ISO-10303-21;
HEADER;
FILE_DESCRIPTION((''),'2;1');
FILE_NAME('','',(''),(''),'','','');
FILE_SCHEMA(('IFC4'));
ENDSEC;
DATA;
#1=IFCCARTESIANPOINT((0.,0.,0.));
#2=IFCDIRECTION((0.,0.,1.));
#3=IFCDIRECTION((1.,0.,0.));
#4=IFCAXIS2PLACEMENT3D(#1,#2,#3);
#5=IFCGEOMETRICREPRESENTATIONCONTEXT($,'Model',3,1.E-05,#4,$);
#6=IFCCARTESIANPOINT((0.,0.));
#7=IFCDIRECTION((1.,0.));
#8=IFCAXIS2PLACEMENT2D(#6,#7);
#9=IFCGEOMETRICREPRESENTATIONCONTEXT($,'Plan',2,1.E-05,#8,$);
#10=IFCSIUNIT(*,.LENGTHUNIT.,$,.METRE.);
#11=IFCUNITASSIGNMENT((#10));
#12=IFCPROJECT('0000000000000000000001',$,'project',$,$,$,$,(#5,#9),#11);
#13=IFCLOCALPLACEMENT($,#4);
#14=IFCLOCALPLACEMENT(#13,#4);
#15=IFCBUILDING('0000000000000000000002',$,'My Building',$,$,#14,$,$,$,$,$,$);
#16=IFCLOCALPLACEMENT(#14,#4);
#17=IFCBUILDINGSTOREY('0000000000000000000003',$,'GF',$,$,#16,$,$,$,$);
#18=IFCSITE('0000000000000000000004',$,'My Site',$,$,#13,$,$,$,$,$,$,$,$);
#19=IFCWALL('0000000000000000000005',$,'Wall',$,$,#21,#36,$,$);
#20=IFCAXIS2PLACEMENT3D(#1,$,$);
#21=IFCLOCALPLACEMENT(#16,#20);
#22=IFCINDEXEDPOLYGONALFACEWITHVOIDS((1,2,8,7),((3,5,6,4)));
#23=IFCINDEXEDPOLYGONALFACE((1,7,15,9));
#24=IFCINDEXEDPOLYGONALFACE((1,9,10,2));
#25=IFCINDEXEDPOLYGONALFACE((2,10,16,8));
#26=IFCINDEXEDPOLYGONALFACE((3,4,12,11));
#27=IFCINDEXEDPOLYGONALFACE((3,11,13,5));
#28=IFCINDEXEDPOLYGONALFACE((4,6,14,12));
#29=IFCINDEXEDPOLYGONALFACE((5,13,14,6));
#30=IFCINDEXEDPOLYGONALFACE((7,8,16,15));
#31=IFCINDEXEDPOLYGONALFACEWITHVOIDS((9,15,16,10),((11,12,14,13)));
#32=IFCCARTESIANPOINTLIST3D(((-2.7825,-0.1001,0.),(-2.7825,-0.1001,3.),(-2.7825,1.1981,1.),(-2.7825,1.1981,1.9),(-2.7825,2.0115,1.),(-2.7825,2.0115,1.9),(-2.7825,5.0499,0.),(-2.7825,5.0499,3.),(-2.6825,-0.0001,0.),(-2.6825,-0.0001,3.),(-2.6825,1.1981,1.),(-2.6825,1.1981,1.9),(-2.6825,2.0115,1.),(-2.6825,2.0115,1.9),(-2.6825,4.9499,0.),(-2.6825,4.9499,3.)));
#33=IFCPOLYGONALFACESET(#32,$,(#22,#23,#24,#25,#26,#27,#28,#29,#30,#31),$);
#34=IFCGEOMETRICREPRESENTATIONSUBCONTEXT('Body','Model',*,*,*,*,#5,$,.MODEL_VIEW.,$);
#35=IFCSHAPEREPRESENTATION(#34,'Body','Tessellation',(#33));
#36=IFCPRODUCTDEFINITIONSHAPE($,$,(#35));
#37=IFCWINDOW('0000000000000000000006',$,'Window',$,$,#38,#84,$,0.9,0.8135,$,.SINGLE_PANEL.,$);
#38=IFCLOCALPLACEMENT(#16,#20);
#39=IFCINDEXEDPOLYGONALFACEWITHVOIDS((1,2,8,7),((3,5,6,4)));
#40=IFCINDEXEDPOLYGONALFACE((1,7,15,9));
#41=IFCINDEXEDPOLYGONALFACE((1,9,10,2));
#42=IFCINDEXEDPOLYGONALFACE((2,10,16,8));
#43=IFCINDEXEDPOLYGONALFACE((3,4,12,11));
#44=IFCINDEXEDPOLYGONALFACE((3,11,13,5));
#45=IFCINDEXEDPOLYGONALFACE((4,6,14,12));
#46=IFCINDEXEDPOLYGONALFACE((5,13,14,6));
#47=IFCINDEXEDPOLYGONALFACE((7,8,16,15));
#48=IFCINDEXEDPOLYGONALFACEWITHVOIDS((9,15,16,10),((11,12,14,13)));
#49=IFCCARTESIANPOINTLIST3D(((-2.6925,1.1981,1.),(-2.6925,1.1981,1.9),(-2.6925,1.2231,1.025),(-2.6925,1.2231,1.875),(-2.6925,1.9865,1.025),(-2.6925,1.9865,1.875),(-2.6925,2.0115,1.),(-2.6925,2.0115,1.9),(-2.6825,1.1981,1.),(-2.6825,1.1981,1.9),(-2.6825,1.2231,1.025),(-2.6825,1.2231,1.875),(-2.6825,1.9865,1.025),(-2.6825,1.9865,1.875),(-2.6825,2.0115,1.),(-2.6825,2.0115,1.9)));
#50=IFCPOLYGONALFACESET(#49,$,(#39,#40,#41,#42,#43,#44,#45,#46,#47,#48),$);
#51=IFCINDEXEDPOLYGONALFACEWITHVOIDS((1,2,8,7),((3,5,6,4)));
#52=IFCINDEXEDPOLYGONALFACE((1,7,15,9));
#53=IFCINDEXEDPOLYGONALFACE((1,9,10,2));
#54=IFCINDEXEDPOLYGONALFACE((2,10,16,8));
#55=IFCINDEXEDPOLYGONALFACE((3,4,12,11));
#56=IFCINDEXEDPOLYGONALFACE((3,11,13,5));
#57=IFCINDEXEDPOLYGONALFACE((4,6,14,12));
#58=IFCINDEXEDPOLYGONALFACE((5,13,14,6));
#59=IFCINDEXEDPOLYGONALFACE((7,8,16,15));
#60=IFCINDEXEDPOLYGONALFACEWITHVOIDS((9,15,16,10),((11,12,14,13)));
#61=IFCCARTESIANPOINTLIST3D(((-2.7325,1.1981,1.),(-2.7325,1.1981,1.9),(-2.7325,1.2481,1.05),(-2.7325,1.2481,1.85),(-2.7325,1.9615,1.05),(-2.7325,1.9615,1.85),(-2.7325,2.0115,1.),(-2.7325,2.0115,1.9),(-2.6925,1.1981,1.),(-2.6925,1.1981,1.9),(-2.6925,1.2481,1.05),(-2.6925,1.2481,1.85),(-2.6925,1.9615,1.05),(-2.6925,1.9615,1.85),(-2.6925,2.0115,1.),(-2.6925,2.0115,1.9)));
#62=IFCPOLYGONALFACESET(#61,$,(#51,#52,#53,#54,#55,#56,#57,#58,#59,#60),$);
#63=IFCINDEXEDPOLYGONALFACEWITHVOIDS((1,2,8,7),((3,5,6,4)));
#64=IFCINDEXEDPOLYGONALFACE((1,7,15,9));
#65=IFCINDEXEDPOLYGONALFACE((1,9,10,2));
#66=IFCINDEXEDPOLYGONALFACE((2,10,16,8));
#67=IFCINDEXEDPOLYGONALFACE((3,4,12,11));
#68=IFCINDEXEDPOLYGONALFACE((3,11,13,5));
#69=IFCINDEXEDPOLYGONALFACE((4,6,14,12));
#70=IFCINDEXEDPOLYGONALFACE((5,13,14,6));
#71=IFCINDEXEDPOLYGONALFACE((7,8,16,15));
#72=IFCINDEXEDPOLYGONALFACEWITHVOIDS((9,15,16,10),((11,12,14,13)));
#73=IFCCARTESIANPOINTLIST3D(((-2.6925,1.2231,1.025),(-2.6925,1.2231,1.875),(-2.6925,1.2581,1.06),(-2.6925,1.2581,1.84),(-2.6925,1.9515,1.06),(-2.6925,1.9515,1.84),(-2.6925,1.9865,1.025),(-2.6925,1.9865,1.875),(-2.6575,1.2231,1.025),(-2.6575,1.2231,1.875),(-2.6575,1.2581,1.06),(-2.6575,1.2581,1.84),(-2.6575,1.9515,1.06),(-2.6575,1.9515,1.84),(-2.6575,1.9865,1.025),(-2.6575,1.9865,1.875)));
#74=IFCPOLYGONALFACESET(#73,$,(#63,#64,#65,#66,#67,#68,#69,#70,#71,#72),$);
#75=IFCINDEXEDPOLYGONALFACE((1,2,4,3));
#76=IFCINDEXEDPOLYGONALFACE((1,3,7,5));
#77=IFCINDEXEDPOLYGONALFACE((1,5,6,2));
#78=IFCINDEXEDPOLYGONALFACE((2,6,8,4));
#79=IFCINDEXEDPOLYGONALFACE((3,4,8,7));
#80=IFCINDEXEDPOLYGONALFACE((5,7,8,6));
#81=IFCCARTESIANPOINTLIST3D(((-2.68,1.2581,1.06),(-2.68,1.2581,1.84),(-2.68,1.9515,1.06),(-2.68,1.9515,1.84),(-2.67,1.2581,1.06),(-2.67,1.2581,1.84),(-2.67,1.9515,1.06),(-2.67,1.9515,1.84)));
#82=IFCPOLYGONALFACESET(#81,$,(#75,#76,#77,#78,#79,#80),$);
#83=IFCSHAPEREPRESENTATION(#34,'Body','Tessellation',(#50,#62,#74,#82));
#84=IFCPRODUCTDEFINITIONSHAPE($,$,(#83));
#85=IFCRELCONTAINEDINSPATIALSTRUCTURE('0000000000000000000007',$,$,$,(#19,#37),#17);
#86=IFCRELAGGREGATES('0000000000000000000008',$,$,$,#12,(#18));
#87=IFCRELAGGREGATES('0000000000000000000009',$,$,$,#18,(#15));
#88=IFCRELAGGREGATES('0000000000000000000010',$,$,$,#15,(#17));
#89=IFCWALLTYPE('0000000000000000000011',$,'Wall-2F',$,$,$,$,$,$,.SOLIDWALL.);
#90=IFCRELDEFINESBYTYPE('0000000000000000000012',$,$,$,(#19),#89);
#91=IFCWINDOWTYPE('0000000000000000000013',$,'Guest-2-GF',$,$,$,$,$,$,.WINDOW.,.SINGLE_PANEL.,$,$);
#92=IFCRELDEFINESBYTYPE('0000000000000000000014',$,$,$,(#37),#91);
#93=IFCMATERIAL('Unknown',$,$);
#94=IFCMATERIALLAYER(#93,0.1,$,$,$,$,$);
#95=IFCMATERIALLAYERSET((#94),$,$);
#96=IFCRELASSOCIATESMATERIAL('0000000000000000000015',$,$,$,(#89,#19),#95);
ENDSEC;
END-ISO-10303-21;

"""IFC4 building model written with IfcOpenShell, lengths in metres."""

from ifc_helpers import new_model, entity, si_unit, frame, origin_with_axes, origin_2d_with_axis, place, context, subcontext, project, spatial, line, indexed_curve, outline, extrude, shape, source, transform, mapped, material, layer, layer_set, layer_usage, type_object, type_shapes, element, fill, save


model = new_model("IFC4")

# Units and contexts
model_context = context("Model", 3, precision=1e-05, world=origin_with_axes())
plan_context = context("Plan", 2, precision=1e-05, world=origin_2d_with_axis())
body_context_1 = subcontext(model_context, "Body", "Model", "MODEL_VIEW")
body_context_2 = subcontext(plan_context, "Body", "Plan", "PLAN_VIEW")
ifc_project = project(units=[si_unit("LENGTHUNIT", "METRE")], contexts=[model_context, plan_context])

# Site, building, storey
site_placement = place(None, origin_with_axes())
site = spatial("IfcSite", under=ifc_project, at=site_placement, Name="My Site")
building_placement = place(site_placement, origin_with_axes())
building = spatial("IfcBuilding", under=site, at=building_placement, Name="My Building")
storey_placement = place(building_placement, origin_with_axes())
storey = spatial("IfcBuildingStorey", under=building, at=storey_placement, Name="GF")

# Shared definitions
ifc_material_1 = material(Name="Unknown")

# Shared definitions
ifc_layer_1 = layer(ifc_material_1, 0.1)
ifc_layer_set_1 = layer_set([ifc_layer_1])
wall_type = type_object("IfcWallType", Name="Wall-2F", PredefinedType="SOLIDWALL", material=ifc_layer_set_1)

# Wall, opening, window
ifc_layer_usage_1 = layer_usage(ifc_layer_set_1, "AXIS2", "POSITIVE", 0.0)
wall_1_placement = place(storey_placement, frame((-2.7825, 5.0499, 0.0), z_axis=(0.0, 0.0, 1.0), x_axis=(0.0, -1.0, 0.0)))
wall_1 = element("IfcWall", 1, at=wall_1_placement, inside=storey, type_object=wall_type, material=ifc_layer_usage_1, Name="Wall", context=body_context_1, shape_type="SweptSolid", body=[
    extrude(outline(indexed_curve([(0.0, 0.0), (0.1, 0.1), (5.05, 0.1), (5.15, 0.0)], segments=[line(1, 2, 3, 4, 1)])), origin_with_axes(), (0.0, 0.0, 1.0), 3.0),
])
shared_shape_1 = source(origin_with_axes(), body_context_1, "Body", "SweptSolid", [
    extrude(outline(indexed_curve([(0.0, 0.0), (0.8135, 0.0), (0.8135, 0.9), (0.0, 0.9)], segments=[line(1, 2, 3, 4, 1)])), frame((0.0, -0.6, 0.0), z_axis=(0.0, -1.0, 0.0), x_axis=(1.0, 0.0, 0.0)), (0.0, 0.0, -1.0), 1.2),
])
opening_1_placement = place(wall_1_placement, frame((3.0384, 0.0, 1.0), z_axis=(0.0, 0.0, 1.0), x_axis=(1.0, 0.0, 0.0)))
opening_1 = element("IfcOpeningElement", 2, at=opening_1_placement, cuts=wall_1, PredefinedType="OPENING", context=body_context_1, shape_type="MappedRepresentation", body=[
    mapped(shared_shape_1, transform((0.0, 0.0, 0.0), x_axis=(1.0, 0.0, 0.0), y_axis=(0.0, 1.0, 0.0), z_axis=(0.0, 0.0, 1.0), scale=1.0)),
])
window_type_1 = type_object("IfcWindowType", Name="Guest-2-GF", PartitioningType="SINGLE_PANEL", PredefinedType="WINDOW")
shared_shape_2 = source(origin_with_axes(), body_context_1, "Body", "SweptSolid", [
    extrude(outline(indexed_curve([(0.0, 0.0), (0.8135, 0.0), (0.8135, 0.9), (0.0, 0.9)], segments=[line(1, 2, 3, 4, 1)]), holes=[indexed_curve([(0.025, 0.025), (0.7885, 0.025), (0.7885, 0.875), (0.025, 0.875)], segments=[line(1, 2, 3, 4, 1)])]), frame((0.0, 0.09, 0.0), z_axis=(0.0, -1.0, 0.0), x_axis=(1.0, 0.0, 0.0)), (0.0, 0.0, -1.0), 0.01),
    extrude(outline(indexed_curve([(0.0, 0.0), (0.8135, 0.0), (0.8135, 0.9), (0.0, 0.9)], segments=[line(1, 2, 3, 4, 1)]), holes=[indexed_curve([(0.05, 0.05), (0.7635, 0.05), (0.7635, 0.85), (0.05, 0.85)], segments=[line(1, 2, 3, 4, 1)])]), frame((0.0, 0.05, 0.0), z_axis=(0.0, -1.0, 0.0), x_axis=(1.0, 0.0, 0.0)), (0.0, 0.0, -1.0), 0.04),
    extrude(outline(indexed_curve([(0.0, 0.0), (0.7635, 0.0), (0.7635, 0.85), (0.0, 0.85)], segments=[line(1, 2, 3, 4, 1)]), holes=[indexed_curve([(0.035, 0.035), (0.7285, 0.035), (0.7285, 0.815), (0.035, 0.815)], segments=[line(1, 2, 3, 4, 1)])]), frame((0.025, 0.09, 0.025), z_axis=(0.0, -1.0, 0.0), x_axis=(1.0, 0.0, 0.0)), (0.0, 0.0, -1.0), 0.035),
    extrude(outline(indexed_curve([(0.035, 0.035), (0.7285, 0.035), (0.7285, 0.815), (0.035, 0.815)], segments=[line(1, 2, 3, 4, 1)])), frame((0.025, 0.1025, 0.025), z_axis=(0.0, -1.0, 0.0), x_axis=(1.0, 0.0, 0.0)), (0.0, 0.0, -1.0), 0.01),
])
shared_shape_3 = source(origin_with_axes(), body_context_2, "Body", "Curve2D", [
    entity("IfcIndexedPolyCurve", entity("IfcCartesianPointList2D", [[0.05, 0.05], [0.7635, 0.05]])),
    entity("IfcIndexedPolyCurve", entity("IfcCartesianPointList2D", [[0.0, 0.1], [0.025, 0.1], [0.025, 0.09], [0.05, 0.09], [0.05, 0.05], [0.0, 0.05]]), [entity("IfcLineIndex", [1, 2, 3, 4, 5, 6, 1])]),
    entity("IfcIndexedPolyCurve", entity("IfcCartesianPointList2D", [[0.8135, 0.1], [0.7885, 0.1], [0.7885, 0.09], [0.7635, 0.09], [0.7635, 0.05], [0.8135, 0.05]]), [entity("IfcLineIndex", [1, 2, 3, 4, 5, 6, 1])]),
    entity("IfcIndexedPolyCurve", entity("IfcCartesianPointList2D", [[0.025, 0.09], [0.06, 0.09], [0.06, 0.125], [0.025, 0.125]]), [entity("IfcLineIndex", [1, 2, 3, 4, 1])]),
    entity("IfcIndexedPolyCurve", entity("IfcCartesianPointList2D", [[0.7885, 0.09], [0.7535, 0.09], [0.7535, 0.125], [0.7885, 0.125]]), [entity("IfcLineIndex", [1, 2, 3, 4, 1])]),
    entity("IfcIndexedPolyCurve", entity("IfcCartesianPointList2D", [[0.06, 0.09], [0.7535, 0.09]])),
    entity("IfcIndexedPolyCurve", entity("IfcCartesianPointList2D", [[0.06, 0.125], [0.7535, 0.125]])),
    entity("IfcIndexedPolyCurve", entity("IfcCartesianPointList2D", [[0.06, 0.1075], [0.7535, 0.1075]])),
])
type_shapes(window_type_1, [shared_shape_2, shared_shape_3])
window_1_placement = place(opening_1_placement, frame((0.0, 0.0, 0.0), z_axis=(0.0, 0.0, 1.0), x_axis=(1.0, 0.0, 0.0)))
window_1 = element("IfcWindow", 3, at=window_1_placement, inside=storey, type_object=window_type_1, Name="Window", OverallHeight=0.9, OverallWidth=0.8135, PartitioningType="SINGLE_PANEL", shapes=[
    shape(body_context_1, "Body", "MappedRepresentation", [mapped(shared_shape_2, transform((0.0, 0.0, 0.0), x_axis=(1.0, 0.0, 0.0), y_axis=(0.0, 1.0, 0.0), z_axis=(0.0, 0.0, 1.0), scale=1.0))]),
    shape(body_context_2, "Body", "MappedRepresentation", [mapped(shared_shape_3, transform((0.0, 0.0, 0.0), x_axis=(1.0, 0.0, 0.0), y_axis=(0.0, 1.0, 0.0), z_axis=(0.0, 0.0, 1.0), scale=1.0))]),
])
fill(opening_1, window_1)

save(model, "model.ifc")
